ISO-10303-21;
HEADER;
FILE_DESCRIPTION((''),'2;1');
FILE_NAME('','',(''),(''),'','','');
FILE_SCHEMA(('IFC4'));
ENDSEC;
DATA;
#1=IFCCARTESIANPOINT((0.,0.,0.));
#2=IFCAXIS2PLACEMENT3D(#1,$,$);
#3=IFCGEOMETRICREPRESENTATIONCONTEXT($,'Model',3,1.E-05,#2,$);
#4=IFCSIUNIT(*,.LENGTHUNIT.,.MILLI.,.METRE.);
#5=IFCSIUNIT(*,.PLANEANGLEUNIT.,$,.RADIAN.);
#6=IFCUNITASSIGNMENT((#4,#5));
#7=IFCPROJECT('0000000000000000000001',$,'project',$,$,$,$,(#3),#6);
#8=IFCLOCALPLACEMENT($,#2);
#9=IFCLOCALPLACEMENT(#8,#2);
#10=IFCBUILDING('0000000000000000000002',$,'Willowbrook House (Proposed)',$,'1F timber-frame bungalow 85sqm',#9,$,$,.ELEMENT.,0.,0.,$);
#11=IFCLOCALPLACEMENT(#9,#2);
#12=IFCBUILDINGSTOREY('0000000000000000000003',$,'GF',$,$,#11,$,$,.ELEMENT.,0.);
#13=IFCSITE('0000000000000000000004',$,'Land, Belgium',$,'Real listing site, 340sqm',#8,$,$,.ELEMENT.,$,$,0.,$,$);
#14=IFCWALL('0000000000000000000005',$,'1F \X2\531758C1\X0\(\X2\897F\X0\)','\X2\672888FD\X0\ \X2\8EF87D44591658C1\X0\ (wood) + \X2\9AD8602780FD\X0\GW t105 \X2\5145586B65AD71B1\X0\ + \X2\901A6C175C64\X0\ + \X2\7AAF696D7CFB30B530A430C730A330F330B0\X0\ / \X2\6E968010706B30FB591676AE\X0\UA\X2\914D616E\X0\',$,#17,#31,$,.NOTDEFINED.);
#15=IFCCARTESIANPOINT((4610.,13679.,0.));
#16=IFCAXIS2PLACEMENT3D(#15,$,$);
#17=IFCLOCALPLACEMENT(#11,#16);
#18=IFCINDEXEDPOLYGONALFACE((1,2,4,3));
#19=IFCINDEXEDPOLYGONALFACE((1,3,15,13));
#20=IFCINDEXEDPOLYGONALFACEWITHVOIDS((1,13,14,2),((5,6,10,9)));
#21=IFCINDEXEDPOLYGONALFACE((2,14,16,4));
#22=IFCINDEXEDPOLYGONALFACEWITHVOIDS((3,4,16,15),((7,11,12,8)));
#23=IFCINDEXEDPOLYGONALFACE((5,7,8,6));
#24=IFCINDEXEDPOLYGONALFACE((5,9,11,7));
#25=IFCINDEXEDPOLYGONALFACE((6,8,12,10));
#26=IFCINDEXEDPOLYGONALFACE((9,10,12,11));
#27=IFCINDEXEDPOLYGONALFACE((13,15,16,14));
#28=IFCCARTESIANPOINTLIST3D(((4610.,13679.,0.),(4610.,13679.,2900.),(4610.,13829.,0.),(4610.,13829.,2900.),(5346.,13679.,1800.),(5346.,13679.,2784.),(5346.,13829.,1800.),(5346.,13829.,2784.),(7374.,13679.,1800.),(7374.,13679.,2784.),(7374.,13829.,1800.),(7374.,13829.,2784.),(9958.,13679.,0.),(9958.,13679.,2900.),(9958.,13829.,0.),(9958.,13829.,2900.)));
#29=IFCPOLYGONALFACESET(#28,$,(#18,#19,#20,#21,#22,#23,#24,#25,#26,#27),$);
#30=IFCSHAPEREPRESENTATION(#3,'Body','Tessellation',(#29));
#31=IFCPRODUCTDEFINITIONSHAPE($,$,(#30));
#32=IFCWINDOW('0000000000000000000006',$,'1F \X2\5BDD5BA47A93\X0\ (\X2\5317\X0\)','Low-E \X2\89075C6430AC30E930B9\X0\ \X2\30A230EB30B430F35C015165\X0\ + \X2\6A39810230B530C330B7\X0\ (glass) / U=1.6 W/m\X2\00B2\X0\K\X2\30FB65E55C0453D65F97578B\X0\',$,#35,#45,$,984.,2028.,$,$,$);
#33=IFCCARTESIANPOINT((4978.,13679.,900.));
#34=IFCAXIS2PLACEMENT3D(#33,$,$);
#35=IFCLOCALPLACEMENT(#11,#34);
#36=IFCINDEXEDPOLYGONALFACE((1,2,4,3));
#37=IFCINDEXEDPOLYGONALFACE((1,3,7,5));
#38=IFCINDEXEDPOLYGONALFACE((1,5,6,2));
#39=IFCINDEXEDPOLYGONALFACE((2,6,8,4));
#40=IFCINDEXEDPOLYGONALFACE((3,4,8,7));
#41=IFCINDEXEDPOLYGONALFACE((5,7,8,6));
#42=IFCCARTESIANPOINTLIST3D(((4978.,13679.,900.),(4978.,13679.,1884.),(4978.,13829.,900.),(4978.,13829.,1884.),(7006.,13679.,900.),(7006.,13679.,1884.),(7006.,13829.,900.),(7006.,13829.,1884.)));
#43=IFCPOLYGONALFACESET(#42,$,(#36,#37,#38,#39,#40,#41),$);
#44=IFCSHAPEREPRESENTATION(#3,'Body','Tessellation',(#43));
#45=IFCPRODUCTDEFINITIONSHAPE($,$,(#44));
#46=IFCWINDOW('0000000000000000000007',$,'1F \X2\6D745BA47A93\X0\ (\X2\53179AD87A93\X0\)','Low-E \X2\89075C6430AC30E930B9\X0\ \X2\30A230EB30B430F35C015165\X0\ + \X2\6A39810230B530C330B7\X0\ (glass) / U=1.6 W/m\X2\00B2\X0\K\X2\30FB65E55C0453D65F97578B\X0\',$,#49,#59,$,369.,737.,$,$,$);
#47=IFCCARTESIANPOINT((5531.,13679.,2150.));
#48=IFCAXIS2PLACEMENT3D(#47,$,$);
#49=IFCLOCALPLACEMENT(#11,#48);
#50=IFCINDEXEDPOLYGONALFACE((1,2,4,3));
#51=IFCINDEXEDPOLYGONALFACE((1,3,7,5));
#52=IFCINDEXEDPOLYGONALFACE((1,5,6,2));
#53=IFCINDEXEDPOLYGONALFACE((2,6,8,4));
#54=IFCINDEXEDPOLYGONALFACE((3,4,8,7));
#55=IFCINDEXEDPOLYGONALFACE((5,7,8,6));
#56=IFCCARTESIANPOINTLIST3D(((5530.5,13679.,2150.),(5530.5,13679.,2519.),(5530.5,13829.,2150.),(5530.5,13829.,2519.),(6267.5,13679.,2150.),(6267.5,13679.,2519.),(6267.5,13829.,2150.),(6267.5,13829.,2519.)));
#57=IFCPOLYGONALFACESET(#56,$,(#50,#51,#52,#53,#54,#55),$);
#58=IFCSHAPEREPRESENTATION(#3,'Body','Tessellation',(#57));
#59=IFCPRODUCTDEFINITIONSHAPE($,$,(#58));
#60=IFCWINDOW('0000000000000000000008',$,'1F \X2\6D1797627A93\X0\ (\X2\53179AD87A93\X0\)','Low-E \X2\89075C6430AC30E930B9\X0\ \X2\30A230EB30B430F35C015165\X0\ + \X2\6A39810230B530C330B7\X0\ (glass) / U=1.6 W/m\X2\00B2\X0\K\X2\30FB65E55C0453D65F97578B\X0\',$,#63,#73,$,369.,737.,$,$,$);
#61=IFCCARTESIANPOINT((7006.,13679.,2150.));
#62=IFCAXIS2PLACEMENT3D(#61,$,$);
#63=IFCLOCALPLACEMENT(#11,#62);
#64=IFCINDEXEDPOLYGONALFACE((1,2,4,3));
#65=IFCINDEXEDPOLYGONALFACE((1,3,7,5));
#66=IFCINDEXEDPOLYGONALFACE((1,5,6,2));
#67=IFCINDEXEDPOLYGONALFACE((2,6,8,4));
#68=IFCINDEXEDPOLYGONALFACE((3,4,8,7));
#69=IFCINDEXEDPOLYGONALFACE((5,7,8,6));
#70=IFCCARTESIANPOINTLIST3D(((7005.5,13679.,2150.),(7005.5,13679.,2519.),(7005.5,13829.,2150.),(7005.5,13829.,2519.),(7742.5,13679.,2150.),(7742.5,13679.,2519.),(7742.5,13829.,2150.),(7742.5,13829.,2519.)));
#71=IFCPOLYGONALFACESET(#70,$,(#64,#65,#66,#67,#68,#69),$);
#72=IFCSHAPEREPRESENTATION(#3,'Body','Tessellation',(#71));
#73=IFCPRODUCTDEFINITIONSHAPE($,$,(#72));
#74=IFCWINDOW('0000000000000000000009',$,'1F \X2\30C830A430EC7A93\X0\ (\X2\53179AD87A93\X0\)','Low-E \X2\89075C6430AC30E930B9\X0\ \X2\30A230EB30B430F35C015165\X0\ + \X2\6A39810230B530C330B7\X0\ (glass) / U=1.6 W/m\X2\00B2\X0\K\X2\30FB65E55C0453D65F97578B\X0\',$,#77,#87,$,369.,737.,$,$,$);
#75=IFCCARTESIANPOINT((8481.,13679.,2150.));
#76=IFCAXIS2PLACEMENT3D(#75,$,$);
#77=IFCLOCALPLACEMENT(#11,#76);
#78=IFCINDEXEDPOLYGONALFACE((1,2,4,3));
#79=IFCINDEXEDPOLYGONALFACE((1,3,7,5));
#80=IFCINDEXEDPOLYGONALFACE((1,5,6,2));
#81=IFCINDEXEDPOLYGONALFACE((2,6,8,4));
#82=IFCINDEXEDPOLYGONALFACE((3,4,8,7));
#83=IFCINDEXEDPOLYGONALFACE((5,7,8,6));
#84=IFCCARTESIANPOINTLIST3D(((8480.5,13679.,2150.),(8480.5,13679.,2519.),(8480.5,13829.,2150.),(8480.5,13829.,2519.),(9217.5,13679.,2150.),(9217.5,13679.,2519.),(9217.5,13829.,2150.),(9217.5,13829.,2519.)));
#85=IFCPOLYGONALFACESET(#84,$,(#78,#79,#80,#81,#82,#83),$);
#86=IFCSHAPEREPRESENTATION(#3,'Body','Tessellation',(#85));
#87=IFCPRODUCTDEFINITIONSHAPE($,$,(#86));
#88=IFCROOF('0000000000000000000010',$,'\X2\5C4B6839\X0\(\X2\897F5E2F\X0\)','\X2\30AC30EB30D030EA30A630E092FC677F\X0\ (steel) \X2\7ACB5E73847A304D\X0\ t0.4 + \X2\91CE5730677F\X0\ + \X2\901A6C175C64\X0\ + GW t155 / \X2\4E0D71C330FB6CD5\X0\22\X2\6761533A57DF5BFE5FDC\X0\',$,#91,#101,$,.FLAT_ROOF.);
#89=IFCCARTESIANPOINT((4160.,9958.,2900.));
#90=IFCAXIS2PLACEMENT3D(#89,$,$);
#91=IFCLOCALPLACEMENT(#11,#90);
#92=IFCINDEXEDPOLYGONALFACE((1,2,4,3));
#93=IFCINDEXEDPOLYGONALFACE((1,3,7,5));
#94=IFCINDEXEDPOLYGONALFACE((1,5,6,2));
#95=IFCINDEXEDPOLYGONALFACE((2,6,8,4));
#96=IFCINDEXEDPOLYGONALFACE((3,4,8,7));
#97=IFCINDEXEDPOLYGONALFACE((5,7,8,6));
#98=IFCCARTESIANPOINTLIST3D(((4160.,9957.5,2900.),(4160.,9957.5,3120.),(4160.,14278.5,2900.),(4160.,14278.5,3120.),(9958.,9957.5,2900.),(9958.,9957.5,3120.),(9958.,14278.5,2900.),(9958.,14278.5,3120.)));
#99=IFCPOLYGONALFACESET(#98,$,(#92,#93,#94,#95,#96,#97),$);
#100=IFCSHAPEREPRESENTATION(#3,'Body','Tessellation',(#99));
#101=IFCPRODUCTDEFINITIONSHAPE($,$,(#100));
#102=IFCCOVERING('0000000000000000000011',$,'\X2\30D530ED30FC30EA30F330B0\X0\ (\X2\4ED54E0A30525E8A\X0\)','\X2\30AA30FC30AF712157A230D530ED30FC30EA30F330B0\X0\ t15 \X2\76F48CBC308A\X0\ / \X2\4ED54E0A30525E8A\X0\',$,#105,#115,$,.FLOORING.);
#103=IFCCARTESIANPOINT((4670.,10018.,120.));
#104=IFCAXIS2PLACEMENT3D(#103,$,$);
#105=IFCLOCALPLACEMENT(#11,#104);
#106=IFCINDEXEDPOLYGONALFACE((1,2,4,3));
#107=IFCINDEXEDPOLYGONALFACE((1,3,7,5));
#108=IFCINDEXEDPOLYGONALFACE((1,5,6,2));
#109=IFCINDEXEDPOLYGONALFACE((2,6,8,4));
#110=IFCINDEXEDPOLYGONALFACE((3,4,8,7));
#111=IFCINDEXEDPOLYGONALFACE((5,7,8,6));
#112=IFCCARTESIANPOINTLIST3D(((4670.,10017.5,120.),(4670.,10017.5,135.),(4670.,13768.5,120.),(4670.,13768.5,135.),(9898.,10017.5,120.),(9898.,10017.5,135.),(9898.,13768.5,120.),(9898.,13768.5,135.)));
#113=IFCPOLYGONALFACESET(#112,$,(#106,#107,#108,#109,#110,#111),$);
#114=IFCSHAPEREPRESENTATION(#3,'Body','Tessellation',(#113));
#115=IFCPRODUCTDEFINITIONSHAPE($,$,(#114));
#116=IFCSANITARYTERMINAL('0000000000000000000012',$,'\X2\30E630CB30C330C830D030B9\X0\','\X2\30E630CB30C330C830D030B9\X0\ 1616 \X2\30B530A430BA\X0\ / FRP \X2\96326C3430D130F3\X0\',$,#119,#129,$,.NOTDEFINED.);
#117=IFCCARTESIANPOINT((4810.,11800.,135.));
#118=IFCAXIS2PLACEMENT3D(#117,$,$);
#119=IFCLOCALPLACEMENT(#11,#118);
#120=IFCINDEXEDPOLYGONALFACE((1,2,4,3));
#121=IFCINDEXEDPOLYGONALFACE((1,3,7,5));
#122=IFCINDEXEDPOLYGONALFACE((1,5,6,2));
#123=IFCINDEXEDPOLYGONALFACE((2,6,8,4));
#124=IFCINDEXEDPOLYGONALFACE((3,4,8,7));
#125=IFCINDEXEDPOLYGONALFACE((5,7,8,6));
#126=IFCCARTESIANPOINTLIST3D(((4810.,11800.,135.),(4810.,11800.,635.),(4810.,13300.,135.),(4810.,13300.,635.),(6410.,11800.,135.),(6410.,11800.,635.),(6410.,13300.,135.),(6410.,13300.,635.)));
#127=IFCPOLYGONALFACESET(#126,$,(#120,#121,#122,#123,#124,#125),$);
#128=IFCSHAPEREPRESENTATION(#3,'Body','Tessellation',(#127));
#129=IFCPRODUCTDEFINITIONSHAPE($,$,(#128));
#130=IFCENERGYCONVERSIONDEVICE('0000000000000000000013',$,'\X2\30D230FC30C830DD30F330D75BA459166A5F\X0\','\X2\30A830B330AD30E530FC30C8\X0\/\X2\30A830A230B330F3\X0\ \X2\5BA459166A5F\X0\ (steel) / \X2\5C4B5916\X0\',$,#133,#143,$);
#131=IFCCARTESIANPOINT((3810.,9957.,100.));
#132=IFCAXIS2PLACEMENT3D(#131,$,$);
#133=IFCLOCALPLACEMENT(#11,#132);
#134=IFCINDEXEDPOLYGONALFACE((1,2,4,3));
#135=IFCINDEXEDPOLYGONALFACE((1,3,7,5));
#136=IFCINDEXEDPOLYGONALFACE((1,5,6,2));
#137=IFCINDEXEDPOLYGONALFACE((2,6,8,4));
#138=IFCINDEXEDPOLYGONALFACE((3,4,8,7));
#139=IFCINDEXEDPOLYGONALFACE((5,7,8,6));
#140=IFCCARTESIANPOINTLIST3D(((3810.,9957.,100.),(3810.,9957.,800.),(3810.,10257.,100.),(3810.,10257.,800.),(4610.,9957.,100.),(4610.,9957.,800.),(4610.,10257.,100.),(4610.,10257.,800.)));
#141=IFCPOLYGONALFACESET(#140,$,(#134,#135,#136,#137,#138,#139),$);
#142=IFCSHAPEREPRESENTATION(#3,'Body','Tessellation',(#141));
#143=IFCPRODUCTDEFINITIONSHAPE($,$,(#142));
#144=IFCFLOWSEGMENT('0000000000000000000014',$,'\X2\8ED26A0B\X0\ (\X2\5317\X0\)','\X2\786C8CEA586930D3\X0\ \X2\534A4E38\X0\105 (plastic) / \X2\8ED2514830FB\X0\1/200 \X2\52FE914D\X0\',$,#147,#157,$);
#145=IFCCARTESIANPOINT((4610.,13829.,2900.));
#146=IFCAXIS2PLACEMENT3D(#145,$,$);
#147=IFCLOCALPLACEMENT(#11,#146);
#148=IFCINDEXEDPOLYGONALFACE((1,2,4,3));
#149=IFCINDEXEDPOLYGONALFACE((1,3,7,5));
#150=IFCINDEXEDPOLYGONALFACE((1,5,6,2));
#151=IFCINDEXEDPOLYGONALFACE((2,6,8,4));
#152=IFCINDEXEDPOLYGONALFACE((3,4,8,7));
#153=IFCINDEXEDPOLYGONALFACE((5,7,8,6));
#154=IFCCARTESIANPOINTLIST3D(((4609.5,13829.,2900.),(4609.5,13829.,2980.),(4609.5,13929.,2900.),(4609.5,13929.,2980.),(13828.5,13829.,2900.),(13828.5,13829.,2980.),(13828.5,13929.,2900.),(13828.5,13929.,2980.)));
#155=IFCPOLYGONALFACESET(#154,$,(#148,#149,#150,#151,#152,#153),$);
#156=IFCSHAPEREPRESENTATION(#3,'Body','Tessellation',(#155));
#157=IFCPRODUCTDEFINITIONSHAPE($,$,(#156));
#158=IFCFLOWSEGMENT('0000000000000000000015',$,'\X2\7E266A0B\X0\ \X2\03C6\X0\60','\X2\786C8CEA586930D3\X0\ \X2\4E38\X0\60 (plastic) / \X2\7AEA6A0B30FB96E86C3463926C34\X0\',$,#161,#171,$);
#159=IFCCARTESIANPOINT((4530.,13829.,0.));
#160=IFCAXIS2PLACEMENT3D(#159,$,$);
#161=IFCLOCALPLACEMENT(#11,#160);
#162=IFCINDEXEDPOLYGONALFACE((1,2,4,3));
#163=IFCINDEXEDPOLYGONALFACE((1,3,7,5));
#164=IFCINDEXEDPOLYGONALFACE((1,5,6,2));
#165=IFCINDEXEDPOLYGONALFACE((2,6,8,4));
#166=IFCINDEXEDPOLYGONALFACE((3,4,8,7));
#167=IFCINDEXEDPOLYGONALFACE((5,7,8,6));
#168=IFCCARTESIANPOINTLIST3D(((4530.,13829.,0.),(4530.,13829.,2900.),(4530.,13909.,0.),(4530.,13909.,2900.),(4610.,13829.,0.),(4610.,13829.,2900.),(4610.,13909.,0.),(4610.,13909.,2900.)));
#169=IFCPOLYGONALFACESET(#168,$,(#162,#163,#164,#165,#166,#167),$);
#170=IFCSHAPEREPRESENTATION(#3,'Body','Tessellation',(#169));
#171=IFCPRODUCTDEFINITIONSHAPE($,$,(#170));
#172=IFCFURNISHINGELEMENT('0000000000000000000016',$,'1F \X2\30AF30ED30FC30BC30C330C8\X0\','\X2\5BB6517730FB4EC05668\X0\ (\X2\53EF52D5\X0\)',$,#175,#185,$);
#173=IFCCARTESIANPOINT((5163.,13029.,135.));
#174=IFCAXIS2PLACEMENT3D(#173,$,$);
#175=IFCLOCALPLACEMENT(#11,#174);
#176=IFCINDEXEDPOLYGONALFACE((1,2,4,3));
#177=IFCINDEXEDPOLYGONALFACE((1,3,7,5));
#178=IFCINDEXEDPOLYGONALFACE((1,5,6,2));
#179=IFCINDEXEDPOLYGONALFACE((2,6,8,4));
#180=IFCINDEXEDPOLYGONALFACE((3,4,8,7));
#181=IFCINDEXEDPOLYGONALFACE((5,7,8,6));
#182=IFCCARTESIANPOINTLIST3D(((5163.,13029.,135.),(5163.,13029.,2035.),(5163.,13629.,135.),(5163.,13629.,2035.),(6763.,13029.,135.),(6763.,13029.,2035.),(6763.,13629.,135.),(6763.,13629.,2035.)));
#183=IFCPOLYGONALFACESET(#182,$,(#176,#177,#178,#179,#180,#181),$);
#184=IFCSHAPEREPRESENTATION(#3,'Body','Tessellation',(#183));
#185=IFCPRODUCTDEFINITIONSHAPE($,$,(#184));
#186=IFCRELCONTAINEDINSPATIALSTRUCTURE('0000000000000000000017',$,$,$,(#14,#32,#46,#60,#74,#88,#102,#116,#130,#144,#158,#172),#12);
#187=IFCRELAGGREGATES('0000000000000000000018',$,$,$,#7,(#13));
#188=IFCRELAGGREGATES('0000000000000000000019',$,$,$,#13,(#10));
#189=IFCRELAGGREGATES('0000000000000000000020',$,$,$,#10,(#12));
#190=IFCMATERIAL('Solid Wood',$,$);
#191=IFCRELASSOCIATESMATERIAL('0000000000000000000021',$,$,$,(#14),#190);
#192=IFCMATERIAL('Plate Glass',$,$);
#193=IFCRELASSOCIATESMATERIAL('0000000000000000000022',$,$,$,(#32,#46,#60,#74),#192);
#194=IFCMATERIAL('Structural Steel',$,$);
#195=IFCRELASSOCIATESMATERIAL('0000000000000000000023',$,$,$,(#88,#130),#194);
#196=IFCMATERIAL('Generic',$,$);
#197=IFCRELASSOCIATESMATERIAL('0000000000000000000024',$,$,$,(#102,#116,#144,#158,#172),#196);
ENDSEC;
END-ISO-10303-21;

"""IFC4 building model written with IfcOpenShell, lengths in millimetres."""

from ifc_helpers import new_model, si_unit, frame, frame_2d, origin, place, context, project, spatial, rectangle, extrude, material, element, fill, save


model = new_model("IFC4")

# Units and contexts
model_context = context("Model", 3, precision=1e-05, world=origin())
ifc_project = project(units=[si_unit("LENGTHUNIT", "METRE", prefix="MILLI"), si_unit("PLANEANGLEUNIT", "RADIAN")], contexts=[model_context])

# Site, building, storey
site_placement = place(None, origin())
site = spatial("IfcSite", under=ifc_project, at=site_placement, Name="Land, Belgium", ObjectType="Real listing site, 340sqm", CompositionType="ELEMENT", RefElevation=0.0)
building_placement = place(site_placement, origin())
building = spatial("IfcBuilding", under=site, at=building_placement, Name="Willowbrook House (Proposed)", ObjectType="1F timber-frame bungalow 85sqm", CompositionType="ELEMENT", ElevationOfRefHeight=0.0, ElevationOfTerrain=0.0)
storey_placement = place(building_placement, origin())
storey = spatial("IfcBuildingStorey", under=building, at=storey_placement, Name="GF", CompositionType="ELEMENT", Elevation=0.0)

# Shared definitions
ifc_material_1 = material(Name="Solid Wood")

# Wall, openings, windows
wall_1_placement = place(storey_placement, frame((4610.0, 13679.0, 0.0)))
wall_1 = element("IfcWall", 1, at=wall_1_placement, inside=storey, material=ifc_material_1, Name="1F 北壁(西)", Description="木製 軸組外壁 (wood) + 高性能GW t105 充填断熱 + 通気層 + 窯業系サイディング / 準耐火・外皮UA配慮", PredefinedType="NOTDEFINED", context=model_context, shape_type="SweptSolid", body=[
    extrude(rectangle(XDim=5348.0, YDim=150.0, at=frame_2d((2674.0, 75.0))), frame((4610.0, 13679.0, 0.0)), (0.0, 0.0, 1.0), 2900.0),
])
opening_1_placement = place(storey_placement, frame((4978.0, 13679.0, 900.0)))
opening_1 = element("IfcOpeningElement", 2, at=opening_1_placement, cuts=wall_1, PredefinedType="NOTDEFINED", context=model_context, shape_type="SweptSolid", body=[
    extrude(rectangle(XDim=2028.0, YDim=150.0, at=frame_2d((1014.0, 75.0))), frame((4978.0, 13679.0, 900.0)), (0.0, 0.0, 1.0), 984.0),
])
opening_2_placement = place(storey_placement, frame((5531.0, 13679.0, 2150.0)))
opening_2 = element("IfcOpeningElement", 3, at=opening_2_placement, cuts=wall_1, PredefinedType="NOTDEFINED", context=model_context, shape_type="SweptSolid", body=[
    extrude(rectangle(XDim=737.0, YDim=150.0, at=frame_2d((368.0, 75.0))), frame((5531.0, 13679.0, 2150.0)), (0.0, 0.0, 1.0), 369.0),
])
opening_3_placement = place(storey_placement, frame((7006.0, 13679.0, 2150.0)))
opening_3 = element("IfcOpeningElement", 4, at=opening_3_placement, cuts=wall_1, PredefinedType="NOTDEFINED", context=model_context, shape_type="SweptSolid", body=[
    extrude(rectangle(XDim=737.0, YDim=150.0, at=frame_2d((368.0, 75.0))), frame((7006.0, 13679.0, 2150.0)), (0.0, 0.0, 1.0), 369.0),
])
opening_4_placement = place(storey_placement, frame((8481.0, 13679.0, 2150.0)))
opening_4 = element("IfcOpeningElement", 5, at=opening_4_placement, cuts=wall_1, PredefinedType="NOTDEFINED", context=model_context, shape_type="SweptSolid", body=[
    extrude(rectangle(XDim=737.0, YDim=150.0, at=frame_2d((368.0, 75.0))), frame((8481.0, 13679.0, 2150.0)), (0.0, 0.0, 1.0), 369.0),
])
ifc_material_2 = material(Name="Plate Glass")
window_1_placement = place(storey_placement, frame((4978.0, 13679.0, 900.0)))
window_1 = element("IfcWindow", 6, at=window_1_placement, inside=storey, material=ifc_material_2, Name="1F 寝室窓 (北)", Description="Low-E 複層ガラス アルゴン封入 + 樹脂サッシ (glass) / U=1.6 W/m²K・日射取得型", OverallHeight=984.0, OverallWidth=2028.0, context=model_context, shape_type="SweptSolid", body=[
    extrude(rectangle(XDim=2028.0, YDim=150.0, at=frame_2d((1014.0, 75.0))), frame((4978.0, 13679.0, 900.0)), (0.0, 0.0, 1.0), 984.0),
])
fill(opening_1, window_1)
window_2_placement = place(storey_placement, frame((5531.0, 13679.0, 2150.0)))
window_2 = element("IfcWindow", 7, at=window_2_placement, inside=storey, material=ifc_material_2, Name="1F 浴室窓 (北高窓)", Description="Low-E 複層ガラス アルゴン封入 + 樹脂サッシ (glass) / U=1.6 W/m²K・日射取得型", OverallHeight=369.0, OverallWidth=737.0, context=model_context, shape_type="SweptSolid", body=[
    extrude(rectangle(XDim=737.0, YDim=150.0, at=frame_2d((368.0, 75.0))), frame((5531.0, 13679.0, 2150.0)), (0.0, 0.0, 1.0), 369.0),
])
fill(opening_2, window_2)
window_3_placement = place(storey_placement, frame((7006.0, 13679.0, 2150.0)))
window_3 = element("IfcWindow", 8, at=window_3_placement, inside=storey, material=ifc_material_2, Name="1F 洗面窓 (北高窓)", Description="Low-E 複層ガラス アルゴン封入 + 樹脂サッシ (glass) / U=1.6 W/m²K・日射取得型", OverallHeight=369.0, OverallWidth=737.0, context=model_context, shape_type="SweptSolid", body=[
    extrude(rectangle(XDim=737.0, YDim=150.0, at=frame_2d((368.0, 75.0))), frame((7006.0, 13679.0, 2150.0)), (0.0, 0.0, 1.0), 369.0),
])
fill(opening_3, window_3)
window_4_placement = place(storey_placement, frame((8481.0, 13679.0, 2150.0)))
window_4 = element("IfcWindow", 9, at=window_4_placement, inside=storey, material=ifc_material_2, Name="1F トイレ窓 (北高窓)", Description="Low-E 複層ガラス アルゴン封入 + 樹脂サッシ (glass) / U=1.6 W/m²K・日射取得型", OverallHeight=369.0, OverallWidth=737.0, context=model_context, shape_type="SweptSolid", body=[
    extrude(rectangle(XDim=737.0, YDim=150.0, at=frame_2d((368.0, 75.0))), frame((8481.0, 13679.0, 2150.0)), (0.0, 0.0, 1.0), 369.0),
])
fill(opening_4, window_4)

# Roof
ifc_material_3 = material(Name="Structural Steel")
roof_placement = place(storey_placement, frame((4160.0, 9958.0, 2900.0)))
element("IfcRoof", 10, at=roof_placement, inside=storey, material=ifc_material_3, Name="屋根(西帯)", Description="ガルバリウム鋼板 (steel) 立平葺き t0.4 + 野地板 + 通気層 + GW t155 / 不燃・法22条区域対応", PredefinedType="FLAT_ROOF", context=model_context, shape_type="SweptSolid", body=[
    extrude(rectangle(XDim=5798.0, YDim=4321.0, at=frame_2d((2899.0, 2160.0))), frame((4160.0, 9958.0, 2900.0)), (0.0, 0.0, 1.0), 220.0),
])

# Covering
ifc_material_4 = material(Name="Generic")
covering_placement = place(storey_placement, frame((4670.0, 10018.0, 120.0)))
element("IfcCovering", 11, at=covering_placement, inside=storey, material=ifc_material_4, Name="フローリング (仕上げ床)", Description="オーク無垢フローリング t15 直貼り / 仕上げ床", PredefinedType="FLOORING", context=model_context, shape_type="SweptSolid", body=[
    extrude(rectangle(XDim=5228.0, YDim=3751.0, at=frame_2d((2614.0, 1875.0))), frame((4670.0, 10018.0, 120.0)), (0.0, 0.0, 1.0), 15.0),
])

# Sanitary terminal
sanitary_terminal_placement = place(storey_placement, frame((4810.0, 11800.0, 135.0)))
element("IfcSanitaryTerminal", 12, at=sanitary_terminal_placement, inside=storey, material=ifc_material_4, Name="ユニットバス", Description="ユニットバス 1616 サイズ / FRP 防水パン", PredefinedType="NOTDEFINED", context=model_context, shape_type="SweptSolid", body=[
    extrude(rectangle(XDim=1600.0, YDim=1500.0, at=frame_2d((800.0, 750.0))), frame((4810.0, 11800.0, 135.0)), (0.0, 0.0, 1.0), 500.0),
])

# Energy conversion device
energy_conversion_device_placement = place(storey_placement, frame((3810.0, 9957.0, 100.0)))
element("IfcEnergyConversionDevice", 13, at=energy_conversion_device_placement, inside=storey, material=ifc_material_3, Name="ヒートポンプ室外機", Description="エコキュート/エアコン 室外機 (steel) / 屋外", context=model_context, shape_type="SweptSolid", body=[
    extrude(rectangle(XDim=800.0, YDim=300.0, at=frame_2d((400.0, 150.0))), frame((3810.0, 9957.0, 100.0)), (0.0, 0.0, 1.0), 700.0),
])

# Flow segments
flow_segment_1_placement = place(storey_placement, frame((4610.0, 13829.0, 2900.0)))
element("IfcFlowSegment", 14, at=flow_segment_1_placement, inside=storey, material=ifc_material_4, Name="軒樋 (北)", Description="硬質塩ビ 半丸105 (plastic) / 軒先・1/200 勾配", context=model_context, shape_type="SweptSolid", body=[
    extrude(rectangle(XDim=9219.0, YDim=100.0, at=frame_2d((4609.0, 50.0))), frame((4610.0, 13829.0, 2900.0)), (0.0, 0.0, 1.0), 80.0),
])
flow_segment_2_placement = place(storey_placement, frame((4530.0, 13829.0, 0.0)))
element("IfcFlowSegment", 15, at=flow_segment_2_placement, inside=storey, material=ifc_material_4, Name="縦樋 φ60", Description="硬質塩ビ 丸60 (plastic) / 竪樋・雨水排水", context=model_context, shape_type="SweptSolid", body=[
    extrude(rectangle(XDim=80.0, YDim=80.0, at=frame_2d((40.0, 40.0))), frame((4530.0, 13829.0, 0.0)), (0.0, 0.0, 1.0), 2900.0),
])

# Furnishing element
furnishing_1_placement = place(storey_placement, frame((5163.0, 13029.0, 135.0)))
element("IfcFurnishingElement", 16, at=furnishing_1_placement, inside=storey, material=ifc_material_4, Name="1F クローゼット", Description="家具・什器 (可動)", context=model_context, shape_type="SweptSolid", body=[
    extrude(rectangle(XDim=1600.0, YDim=600.0, at=frame_2d((800.0, 300.0))), frame((5163.0, 13029.0, 135.0)), (0.0, 0.0, 1.0), 1900.0),
])

save(model, "model.ifc")
